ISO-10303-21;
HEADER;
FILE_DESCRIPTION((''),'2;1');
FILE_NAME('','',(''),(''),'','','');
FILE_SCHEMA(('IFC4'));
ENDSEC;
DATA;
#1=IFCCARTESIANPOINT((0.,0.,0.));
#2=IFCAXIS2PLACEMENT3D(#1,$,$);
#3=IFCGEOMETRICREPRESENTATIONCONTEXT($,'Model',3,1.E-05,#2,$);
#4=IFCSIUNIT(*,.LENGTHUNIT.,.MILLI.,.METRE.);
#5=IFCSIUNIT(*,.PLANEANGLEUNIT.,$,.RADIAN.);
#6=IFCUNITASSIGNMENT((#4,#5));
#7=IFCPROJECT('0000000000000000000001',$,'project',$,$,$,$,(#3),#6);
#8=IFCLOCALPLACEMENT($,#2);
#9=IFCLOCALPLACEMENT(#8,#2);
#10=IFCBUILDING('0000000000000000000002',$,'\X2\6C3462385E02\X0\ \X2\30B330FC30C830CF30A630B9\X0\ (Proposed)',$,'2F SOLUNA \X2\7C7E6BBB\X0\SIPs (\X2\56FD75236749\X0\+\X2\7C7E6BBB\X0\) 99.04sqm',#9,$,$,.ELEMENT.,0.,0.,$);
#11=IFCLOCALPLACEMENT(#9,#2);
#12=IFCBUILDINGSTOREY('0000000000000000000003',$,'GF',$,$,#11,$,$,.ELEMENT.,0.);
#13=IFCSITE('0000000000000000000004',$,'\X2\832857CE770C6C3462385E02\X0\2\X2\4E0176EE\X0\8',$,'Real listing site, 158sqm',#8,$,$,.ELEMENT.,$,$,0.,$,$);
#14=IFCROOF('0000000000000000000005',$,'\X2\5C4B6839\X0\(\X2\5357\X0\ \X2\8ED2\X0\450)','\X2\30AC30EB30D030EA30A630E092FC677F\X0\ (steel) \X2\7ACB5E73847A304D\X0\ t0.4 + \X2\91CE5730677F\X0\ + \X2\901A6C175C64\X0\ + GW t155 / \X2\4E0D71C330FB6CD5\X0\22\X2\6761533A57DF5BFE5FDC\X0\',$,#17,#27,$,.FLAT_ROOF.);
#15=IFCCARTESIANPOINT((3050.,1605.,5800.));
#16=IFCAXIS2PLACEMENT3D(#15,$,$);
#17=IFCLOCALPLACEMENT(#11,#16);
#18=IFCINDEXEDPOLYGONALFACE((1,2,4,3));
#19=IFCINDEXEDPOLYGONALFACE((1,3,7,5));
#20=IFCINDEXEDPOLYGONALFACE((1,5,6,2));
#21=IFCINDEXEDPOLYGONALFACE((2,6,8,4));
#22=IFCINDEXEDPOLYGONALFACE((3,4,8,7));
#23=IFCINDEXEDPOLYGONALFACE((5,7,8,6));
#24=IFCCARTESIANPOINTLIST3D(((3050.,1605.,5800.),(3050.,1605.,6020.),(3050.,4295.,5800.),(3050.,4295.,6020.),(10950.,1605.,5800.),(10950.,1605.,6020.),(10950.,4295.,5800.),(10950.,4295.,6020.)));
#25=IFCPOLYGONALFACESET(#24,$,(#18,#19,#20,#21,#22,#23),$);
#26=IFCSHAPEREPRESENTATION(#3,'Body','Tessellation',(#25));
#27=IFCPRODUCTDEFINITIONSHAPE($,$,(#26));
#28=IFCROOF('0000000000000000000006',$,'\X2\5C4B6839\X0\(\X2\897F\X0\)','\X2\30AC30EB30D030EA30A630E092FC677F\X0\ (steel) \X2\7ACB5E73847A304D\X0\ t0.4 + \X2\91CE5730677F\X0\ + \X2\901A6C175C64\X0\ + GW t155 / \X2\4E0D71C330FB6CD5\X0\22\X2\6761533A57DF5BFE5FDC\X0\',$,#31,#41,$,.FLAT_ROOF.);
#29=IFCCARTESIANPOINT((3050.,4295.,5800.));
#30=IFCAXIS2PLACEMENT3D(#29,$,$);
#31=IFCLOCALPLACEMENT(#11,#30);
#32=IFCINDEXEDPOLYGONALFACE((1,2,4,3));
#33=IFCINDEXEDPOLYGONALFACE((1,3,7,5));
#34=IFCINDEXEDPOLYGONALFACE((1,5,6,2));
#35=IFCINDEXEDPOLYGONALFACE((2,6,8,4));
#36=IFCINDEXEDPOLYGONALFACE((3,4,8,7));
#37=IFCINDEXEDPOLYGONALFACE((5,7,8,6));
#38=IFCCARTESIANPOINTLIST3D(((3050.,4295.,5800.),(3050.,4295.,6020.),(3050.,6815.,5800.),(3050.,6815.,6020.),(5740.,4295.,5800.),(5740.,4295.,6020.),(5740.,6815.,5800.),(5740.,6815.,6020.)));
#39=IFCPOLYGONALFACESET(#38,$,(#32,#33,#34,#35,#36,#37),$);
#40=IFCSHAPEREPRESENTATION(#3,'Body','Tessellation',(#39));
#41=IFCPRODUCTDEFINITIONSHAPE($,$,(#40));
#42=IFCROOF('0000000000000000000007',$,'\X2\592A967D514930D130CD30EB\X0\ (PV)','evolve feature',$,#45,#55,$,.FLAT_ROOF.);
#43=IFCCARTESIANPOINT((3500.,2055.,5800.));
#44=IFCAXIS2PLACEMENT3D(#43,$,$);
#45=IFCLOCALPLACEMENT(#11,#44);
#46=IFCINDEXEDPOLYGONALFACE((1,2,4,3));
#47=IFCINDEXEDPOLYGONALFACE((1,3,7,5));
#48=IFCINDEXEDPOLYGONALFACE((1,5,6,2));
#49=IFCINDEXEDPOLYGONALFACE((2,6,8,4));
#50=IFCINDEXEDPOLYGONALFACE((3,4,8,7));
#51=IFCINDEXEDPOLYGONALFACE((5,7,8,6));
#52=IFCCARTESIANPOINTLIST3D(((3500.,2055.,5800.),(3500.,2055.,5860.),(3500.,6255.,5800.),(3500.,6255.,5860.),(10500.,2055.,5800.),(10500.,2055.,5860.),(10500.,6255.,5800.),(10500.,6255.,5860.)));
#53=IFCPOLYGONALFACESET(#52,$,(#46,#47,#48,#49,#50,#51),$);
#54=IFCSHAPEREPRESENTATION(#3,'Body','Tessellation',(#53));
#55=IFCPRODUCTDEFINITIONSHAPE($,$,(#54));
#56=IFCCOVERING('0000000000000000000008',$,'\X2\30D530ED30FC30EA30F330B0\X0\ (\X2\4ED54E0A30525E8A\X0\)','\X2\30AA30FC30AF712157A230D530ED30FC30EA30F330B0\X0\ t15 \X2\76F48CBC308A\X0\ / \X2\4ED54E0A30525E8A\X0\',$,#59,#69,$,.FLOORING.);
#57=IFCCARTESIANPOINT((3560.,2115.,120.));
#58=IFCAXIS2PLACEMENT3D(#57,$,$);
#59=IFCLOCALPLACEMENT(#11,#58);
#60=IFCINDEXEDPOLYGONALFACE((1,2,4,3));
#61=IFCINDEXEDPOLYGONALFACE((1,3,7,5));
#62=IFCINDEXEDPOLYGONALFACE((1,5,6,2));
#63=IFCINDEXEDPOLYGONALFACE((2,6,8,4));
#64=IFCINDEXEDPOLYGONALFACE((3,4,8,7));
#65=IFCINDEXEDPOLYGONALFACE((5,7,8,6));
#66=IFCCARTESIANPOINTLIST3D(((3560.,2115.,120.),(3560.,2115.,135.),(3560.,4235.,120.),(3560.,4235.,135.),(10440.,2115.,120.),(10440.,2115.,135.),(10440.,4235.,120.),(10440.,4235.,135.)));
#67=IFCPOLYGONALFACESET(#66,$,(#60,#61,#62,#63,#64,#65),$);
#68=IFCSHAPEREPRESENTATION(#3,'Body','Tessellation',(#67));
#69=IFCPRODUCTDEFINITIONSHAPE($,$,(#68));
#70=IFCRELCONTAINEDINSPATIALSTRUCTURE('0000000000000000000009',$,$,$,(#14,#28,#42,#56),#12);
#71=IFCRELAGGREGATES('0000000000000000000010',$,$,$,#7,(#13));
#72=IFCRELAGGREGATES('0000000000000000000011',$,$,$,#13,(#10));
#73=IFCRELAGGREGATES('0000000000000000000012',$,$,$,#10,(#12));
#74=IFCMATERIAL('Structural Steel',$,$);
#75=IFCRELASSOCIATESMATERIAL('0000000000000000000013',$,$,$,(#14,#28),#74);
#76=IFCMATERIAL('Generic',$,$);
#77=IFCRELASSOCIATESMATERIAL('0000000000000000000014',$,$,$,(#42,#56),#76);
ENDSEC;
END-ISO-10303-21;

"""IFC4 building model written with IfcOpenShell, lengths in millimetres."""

from ifc_helpers import new_model, si_unit, frame, frame_2d, origin, place, context, project, spatial, rectangle, extrude, material, element, save


model = new_model("IFC4")

# Units and contexts
model_context = context("Model", 3, precision=1e-05, world=origin())
ifc_project = project(units=[si_unit("LENGTHUNIT", "METRE", prefix="MILLI"), si_unit("PLANEANGLEUNIT", "RADIAN")], contexts=[model_context])

# Site, building, storey
site_placement = place(None, origin())
site = spatial("IfcSite", under=ifc_project, at=site_placement, Name="茨城県水戸市2丁目8", ObjectType="Real listing site, 158sqm", CompositionType="ELEMENT", RefElevation=0.0)
building_placement = place(site_placement, origin())
building = spatial("IfcBuilding", under=site, at=building_placement, Name="水戸市 コートハウス (Proposed)", ObjectType="2F SOLUNA 籾殻SIPs (国産杉+籾殻) 99.04sqm", CompositionType="ELEMENT", ElevationOfRefHeight=0.0, ElevationOfTerrain=0.0)
storey_placement = place(building_placement, origin())
storey = spatial("IfcBuildingStorey", under=building, at=storey_placement, Name="GF", CompositionType="ELEMENT", Elevation=0.0)

# Shared definitions
ifc_material_1 = material(Name="Generic")

# Roofs
ifc_material_2 = material(Name="Structural Steel")
roof_1_placement = place(storey_placement, frame((3050.0, 1605.0, 5800.0)))
element("IfcRoof", 1, at=roof_1_placement, inside=storey, material=ifc_material_2, Name="屋根(南 軒450)", Description="ガルバリウム鋼板 (steel) 立平葺き t0.4 + 野地板 + 通気層 + GW t155 / 不燃・法22条区域対応", PredefinedType="FLAT_ROOF", context=model_context, shape_type="SweptSolid", body=[
    extrude(rectangle(XDim=7900.0, YDim=2690.0, at=frame_2d((3950.0, 1345.0))), frame((3050.0, 1605.0, 5800.0)), (0.0, 0.0, 1.0), 220.0),
])
roof_2_placement = place(storey_placement, frame((3050.0, 4295.0, 5800.0)))
element("IfcRoof", 2, at=roof_2_placement, inside=storey, material=ifc_material_2, Name="屋根(西)", Description="ガルバリウム鋼板 (steel) 立平葺き t0.4 + 野地板 + 通気層 + GW t155 / 不燃・法22条区域対応", PredefinedType="FLAT_ROOF", context=model_context, shape_type="SweptSolid", body=[
    extrude(rectangle(XDim=2690.0, YDim=2520.0, at=frame_2d((1345.0, 1260.0))), frame((3050.0, 4295.0, 5800.0)), (0.0, 0.0, 1.0), 220.0),
])
roof_3_placement = place(storey_placement, frame((3500.0, 2055.0, 5800.0)))
element("IfcRoof", 3, at=roof_3_placement, inside=storey, material=ifc_material_1, Name="太陽光パネル (PV)", Description="evolve feature", PredefinedType="FLAT_ROOF", context=model_context, shape_type="SweptSolid", body=[
    extrude(rectangle(XDim=7000.0, YDim=4200.0, at=frame_2d((3500.0, 2100.0))), frame((3500.0, 2055.0, 5800.0)), (0.0, 0.0, 1.0), 60.0),
])

# Covering
covering_placement = place(storey_placement, frame((3560.0, 2115.0, 120.0)))
element("IfcCovering", 4, at=covering_placement, inside=storey, material=ifc_material_1, Name="フローリング (仕上げ床)", Description="オーク無垢フローリング t15 直貼り / 仕上げ床", PredefinedType="FLOORING", context=model_context, shape_type="SweptSolid", body=[
    extrude(rectangle(XDim=6880.0, YDim=2120.0, at=frame_2d((3440.0, 1060.0))), frame((3560.0, 2115.0, 120.0)), (0.0, 0.0, 1.0), 15.0),
])

save(model, "model.ifc")
